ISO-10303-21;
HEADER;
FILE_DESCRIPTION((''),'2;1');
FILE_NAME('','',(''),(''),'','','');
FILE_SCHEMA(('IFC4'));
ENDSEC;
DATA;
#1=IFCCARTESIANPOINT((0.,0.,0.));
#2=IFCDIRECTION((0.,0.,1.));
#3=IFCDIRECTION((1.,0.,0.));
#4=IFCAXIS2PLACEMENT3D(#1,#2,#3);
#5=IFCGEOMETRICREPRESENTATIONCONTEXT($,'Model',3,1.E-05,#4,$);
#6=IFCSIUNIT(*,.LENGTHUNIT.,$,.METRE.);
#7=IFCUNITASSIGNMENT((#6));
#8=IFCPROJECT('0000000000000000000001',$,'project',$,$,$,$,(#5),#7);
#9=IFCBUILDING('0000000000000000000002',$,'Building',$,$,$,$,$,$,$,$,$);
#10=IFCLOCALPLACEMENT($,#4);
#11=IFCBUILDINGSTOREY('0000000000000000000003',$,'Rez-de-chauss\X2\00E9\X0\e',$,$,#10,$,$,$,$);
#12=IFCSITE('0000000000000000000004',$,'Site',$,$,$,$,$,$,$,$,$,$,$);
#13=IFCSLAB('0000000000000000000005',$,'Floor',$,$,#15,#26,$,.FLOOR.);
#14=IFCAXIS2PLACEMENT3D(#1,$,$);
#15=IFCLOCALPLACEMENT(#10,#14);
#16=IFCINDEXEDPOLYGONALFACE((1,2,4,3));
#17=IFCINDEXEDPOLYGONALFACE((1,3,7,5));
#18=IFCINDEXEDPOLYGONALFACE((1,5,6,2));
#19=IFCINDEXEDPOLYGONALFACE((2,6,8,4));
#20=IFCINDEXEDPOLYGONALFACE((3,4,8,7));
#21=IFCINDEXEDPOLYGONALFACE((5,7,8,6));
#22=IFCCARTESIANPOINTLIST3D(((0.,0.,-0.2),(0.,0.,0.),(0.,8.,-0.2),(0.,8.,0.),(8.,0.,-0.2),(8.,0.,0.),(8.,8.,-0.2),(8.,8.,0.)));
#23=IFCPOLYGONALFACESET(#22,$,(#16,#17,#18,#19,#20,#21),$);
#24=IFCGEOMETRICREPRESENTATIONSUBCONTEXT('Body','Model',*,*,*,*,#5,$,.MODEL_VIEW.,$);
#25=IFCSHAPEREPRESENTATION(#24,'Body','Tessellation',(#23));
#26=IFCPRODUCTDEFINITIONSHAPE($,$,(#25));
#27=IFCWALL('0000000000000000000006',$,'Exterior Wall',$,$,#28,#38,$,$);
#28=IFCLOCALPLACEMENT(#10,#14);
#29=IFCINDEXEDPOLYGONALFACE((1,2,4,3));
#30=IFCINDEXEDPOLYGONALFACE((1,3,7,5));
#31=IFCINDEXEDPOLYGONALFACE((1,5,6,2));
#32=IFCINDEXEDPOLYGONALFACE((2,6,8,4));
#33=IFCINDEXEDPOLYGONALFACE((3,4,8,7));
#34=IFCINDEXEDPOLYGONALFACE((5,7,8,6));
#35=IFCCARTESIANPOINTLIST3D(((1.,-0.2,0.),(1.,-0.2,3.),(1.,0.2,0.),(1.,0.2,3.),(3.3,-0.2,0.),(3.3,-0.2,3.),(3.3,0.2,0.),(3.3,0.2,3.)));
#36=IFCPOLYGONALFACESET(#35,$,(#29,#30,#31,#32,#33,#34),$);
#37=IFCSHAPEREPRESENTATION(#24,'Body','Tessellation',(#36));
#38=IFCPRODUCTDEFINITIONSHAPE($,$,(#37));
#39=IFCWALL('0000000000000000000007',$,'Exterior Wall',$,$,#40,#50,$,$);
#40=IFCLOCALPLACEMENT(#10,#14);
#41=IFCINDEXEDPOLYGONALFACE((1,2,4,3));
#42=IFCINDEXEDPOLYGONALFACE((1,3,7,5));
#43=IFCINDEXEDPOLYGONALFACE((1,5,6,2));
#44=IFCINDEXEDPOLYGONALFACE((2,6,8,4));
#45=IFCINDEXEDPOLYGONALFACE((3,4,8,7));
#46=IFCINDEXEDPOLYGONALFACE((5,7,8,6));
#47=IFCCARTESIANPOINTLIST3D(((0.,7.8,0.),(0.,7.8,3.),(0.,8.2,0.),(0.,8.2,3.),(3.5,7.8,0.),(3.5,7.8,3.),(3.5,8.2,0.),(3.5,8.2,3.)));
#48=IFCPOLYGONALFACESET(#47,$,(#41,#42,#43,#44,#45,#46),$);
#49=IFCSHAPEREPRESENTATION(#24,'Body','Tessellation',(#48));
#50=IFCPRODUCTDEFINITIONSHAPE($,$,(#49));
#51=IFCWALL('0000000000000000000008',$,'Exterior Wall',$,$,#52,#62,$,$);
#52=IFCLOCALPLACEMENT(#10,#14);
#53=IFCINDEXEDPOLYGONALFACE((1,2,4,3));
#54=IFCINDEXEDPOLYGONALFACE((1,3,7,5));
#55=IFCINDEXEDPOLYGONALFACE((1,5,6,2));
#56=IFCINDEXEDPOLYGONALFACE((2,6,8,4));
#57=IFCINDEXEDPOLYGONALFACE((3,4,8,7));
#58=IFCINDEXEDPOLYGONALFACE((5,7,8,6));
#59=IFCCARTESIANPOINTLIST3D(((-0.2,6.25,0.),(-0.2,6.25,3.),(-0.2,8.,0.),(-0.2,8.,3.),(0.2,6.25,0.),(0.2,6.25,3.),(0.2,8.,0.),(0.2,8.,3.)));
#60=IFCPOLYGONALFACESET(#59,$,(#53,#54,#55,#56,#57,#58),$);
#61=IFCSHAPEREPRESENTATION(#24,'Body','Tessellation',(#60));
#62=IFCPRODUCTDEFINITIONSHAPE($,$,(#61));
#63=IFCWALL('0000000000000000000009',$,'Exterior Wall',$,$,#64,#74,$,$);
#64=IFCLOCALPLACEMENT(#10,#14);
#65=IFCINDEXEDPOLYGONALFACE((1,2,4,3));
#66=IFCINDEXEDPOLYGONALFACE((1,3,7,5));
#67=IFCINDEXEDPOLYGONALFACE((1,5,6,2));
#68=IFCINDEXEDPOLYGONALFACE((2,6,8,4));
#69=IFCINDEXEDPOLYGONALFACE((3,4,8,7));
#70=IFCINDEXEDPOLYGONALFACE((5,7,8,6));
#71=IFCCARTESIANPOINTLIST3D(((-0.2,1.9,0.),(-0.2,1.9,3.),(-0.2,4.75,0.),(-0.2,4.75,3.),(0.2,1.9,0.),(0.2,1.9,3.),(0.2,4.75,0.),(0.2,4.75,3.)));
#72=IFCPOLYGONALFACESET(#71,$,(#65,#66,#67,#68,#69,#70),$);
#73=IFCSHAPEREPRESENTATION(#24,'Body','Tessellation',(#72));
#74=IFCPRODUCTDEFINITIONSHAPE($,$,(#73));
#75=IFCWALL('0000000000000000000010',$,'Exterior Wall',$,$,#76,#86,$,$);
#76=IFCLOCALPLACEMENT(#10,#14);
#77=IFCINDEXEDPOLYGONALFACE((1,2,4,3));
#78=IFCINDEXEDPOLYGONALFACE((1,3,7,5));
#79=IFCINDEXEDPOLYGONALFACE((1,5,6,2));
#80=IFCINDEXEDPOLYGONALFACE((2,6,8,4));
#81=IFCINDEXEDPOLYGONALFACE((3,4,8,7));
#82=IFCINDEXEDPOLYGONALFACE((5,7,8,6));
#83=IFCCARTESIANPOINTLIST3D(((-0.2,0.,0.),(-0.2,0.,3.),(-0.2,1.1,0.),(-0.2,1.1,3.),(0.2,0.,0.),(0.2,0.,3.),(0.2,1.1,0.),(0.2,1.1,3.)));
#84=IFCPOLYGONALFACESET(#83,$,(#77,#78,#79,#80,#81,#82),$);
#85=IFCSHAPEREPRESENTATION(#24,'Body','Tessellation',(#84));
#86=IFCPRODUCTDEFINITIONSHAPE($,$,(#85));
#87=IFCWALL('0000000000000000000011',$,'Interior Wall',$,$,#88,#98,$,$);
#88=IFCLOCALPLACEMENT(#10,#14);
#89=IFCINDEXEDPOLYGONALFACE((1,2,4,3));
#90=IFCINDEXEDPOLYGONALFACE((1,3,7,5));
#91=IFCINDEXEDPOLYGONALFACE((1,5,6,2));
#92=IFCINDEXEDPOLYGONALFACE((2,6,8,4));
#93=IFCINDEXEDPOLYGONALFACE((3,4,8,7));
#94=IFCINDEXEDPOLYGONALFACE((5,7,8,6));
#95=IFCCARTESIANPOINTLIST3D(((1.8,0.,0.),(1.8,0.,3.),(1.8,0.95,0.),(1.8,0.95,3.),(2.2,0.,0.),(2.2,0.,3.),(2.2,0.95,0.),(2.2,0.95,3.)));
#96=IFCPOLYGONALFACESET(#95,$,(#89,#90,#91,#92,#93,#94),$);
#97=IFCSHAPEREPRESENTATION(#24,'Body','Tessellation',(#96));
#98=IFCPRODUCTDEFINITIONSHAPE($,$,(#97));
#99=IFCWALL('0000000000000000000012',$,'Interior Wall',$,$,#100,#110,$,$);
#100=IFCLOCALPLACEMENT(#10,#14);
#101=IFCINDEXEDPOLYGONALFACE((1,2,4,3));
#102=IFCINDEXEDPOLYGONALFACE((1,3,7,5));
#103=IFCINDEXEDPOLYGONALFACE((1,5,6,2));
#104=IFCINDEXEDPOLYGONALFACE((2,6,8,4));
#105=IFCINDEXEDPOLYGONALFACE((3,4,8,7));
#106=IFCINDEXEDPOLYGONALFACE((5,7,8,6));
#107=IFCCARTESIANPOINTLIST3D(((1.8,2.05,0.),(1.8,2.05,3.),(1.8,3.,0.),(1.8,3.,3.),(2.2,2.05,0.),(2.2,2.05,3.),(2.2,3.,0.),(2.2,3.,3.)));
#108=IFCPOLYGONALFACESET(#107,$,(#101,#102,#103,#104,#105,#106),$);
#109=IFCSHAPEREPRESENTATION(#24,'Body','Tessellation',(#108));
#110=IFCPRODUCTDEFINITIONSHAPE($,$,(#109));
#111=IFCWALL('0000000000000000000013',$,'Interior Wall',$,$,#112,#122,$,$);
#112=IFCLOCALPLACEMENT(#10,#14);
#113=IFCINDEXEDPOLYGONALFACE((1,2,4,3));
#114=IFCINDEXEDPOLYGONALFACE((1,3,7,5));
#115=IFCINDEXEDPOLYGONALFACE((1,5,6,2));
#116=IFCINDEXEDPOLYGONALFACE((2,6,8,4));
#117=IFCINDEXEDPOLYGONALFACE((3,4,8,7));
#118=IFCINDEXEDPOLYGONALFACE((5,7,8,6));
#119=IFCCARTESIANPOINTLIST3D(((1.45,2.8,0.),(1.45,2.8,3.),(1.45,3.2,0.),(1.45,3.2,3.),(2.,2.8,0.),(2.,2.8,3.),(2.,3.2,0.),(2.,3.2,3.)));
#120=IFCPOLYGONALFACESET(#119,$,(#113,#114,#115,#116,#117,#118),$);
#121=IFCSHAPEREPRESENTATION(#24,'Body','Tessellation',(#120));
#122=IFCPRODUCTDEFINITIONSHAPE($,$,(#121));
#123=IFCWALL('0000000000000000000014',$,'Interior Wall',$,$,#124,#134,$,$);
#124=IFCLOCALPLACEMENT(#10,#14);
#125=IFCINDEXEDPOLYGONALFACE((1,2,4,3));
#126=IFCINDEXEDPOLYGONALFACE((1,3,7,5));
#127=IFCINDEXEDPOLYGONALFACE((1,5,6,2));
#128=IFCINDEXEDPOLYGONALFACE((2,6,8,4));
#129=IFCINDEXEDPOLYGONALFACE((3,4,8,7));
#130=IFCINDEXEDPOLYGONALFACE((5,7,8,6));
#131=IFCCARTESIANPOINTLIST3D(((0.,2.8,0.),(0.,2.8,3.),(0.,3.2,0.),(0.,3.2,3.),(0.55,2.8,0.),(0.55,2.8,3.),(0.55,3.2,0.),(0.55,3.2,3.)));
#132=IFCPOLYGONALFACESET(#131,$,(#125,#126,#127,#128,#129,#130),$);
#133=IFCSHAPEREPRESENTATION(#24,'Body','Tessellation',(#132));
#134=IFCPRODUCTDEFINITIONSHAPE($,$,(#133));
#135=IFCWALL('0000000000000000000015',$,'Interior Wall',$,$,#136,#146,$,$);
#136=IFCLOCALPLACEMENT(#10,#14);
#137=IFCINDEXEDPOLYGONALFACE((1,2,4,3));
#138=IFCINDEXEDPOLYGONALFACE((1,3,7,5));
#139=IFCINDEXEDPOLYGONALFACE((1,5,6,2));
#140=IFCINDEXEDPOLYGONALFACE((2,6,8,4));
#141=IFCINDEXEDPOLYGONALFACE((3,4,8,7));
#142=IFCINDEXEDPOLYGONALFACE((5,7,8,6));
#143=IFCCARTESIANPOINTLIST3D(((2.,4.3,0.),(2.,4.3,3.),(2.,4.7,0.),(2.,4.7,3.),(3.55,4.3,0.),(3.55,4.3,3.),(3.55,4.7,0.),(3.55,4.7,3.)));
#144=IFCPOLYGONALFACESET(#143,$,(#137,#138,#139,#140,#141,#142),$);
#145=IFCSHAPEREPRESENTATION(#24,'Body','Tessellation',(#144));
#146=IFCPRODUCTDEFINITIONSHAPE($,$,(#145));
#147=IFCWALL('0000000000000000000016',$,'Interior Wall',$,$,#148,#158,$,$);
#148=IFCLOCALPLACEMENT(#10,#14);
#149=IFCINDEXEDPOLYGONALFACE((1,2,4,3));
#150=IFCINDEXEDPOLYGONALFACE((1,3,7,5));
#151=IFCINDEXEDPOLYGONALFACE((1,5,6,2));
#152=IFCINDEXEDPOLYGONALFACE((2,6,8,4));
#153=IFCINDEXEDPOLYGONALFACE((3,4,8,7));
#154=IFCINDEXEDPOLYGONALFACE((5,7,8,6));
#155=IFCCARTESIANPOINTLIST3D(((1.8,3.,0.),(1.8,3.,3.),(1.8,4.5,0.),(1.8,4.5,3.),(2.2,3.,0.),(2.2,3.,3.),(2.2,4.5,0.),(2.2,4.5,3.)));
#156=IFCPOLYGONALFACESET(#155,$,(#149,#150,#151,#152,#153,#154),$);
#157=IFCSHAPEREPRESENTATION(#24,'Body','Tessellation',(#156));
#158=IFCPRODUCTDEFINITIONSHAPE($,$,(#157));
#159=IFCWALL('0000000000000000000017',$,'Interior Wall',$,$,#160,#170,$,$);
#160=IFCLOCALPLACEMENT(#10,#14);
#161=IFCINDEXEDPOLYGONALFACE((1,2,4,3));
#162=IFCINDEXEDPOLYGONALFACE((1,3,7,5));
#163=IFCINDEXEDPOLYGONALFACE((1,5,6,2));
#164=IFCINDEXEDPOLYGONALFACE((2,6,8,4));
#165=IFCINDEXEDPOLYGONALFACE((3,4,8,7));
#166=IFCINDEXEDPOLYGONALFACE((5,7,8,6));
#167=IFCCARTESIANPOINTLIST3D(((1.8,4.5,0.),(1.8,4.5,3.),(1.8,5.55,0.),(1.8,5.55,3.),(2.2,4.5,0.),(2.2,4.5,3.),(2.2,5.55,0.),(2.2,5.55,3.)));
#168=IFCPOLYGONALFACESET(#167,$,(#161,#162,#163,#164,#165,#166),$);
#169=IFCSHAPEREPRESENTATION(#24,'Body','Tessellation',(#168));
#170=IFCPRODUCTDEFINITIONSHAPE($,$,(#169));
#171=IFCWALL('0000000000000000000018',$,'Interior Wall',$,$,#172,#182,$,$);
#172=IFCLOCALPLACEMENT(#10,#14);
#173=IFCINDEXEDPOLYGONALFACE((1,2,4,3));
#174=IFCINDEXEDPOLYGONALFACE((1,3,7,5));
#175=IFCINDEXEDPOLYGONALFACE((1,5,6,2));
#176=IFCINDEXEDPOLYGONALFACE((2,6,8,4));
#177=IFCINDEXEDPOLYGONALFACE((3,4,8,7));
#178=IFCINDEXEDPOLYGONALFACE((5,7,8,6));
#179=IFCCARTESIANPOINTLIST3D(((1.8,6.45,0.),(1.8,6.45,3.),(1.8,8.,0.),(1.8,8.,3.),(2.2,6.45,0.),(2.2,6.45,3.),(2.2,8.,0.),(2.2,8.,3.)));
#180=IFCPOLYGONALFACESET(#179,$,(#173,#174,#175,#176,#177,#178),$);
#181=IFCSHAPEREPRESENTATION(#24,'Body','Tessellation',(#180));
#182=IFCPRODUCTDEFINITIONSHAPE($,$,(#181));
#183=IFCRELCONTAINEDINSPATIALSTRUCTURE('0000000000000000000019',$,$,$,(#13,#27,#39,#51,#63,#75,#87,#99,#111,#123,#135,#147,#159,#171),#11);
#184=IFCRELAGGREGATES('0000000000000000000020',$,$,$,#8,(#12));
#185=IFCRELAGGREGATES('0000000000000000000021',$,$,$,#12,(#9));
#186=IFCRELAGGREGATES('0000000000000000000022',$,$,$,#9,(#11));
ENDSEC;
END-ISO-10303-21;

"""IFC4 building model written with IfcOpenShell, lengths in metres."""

from ifc_helpers import new_model, si_unit, frame, origin_with_axes, place, context, subcontext, project, spatial, indexed_curve, outline, extrude, element, save


model = new_model("IFC4")

# Units and contexts
model_context = context("Model", 3, precision=1e-05, world=origin_with_axes())
body_context = subcontext(model_context, "Body", "Model", "MODEL_VIEW")
ifc_project = project(units=[si_unit("LENGTHUNIT", "METRE")], contexts=[model_context])

# Site, building, storey
site = spatial("IfcSite", under=ifc_project, Name="Site")
building = spatial("IfcBuilding", under=site, Name="Building")
storey_placement = place(None, origin_with_axes())
storey = spatial("IfcBuildingStorey", under=building, at=storey_placement, Name="Rez-de-chaussée")

# Slab
slab_placement = place(storey_placement, frame((0.0, 0.0, -0.2), z_axis=(0.0, 0.0, 1.0), x_axis=(1.0, 0.0, 0.0)))
element("IfcSlab", 1, at=slab_placement, inside=storey, Name="Floor", PredefinedType="FLOOR", context=body_context, shape_type="SweptSolid", body=[
    extrude(outline(indexed_curve([(0.0, 0.0), (8.0, 0.0), (8.0, 8.0), (0.0, 8.0)])), None, (0.0, 0.0, 1.0), 0.2),
])

# Walls
wall_1_placement = place(storey_placement, frame((1.0, 0.0, 0.0), z_axis=(0.0, 0.0, 1.0), x_axis=(1.0, 0.0, 0.0)))
element("IfcWall", 2, at=wall_1_placement, inside=storey, Name="Exterior Wall", context=body_context, shape_type="SweptSolid", body=[
    extrude(outline(indexed_curve([(0.0, 0.0), (0.0, 0.4), (2.3, 0.4), (2.3, 0.0), (0.0, 0.0)], self_intersect=False)), frame((0.0, -0.2, 0.0), z_axis=(0.0, 0.0, 1.0), x_axis=(1.0, 0.0, 0.0)), (0.0, 0.0, 1.0), 3.0),
])
wall_2_placement = place(storey_placement, frame((3.5, 8.0, 0.0), z_axis=(0.0, 0.0, 1.0), x_axis=(-1.0, 0.0, 0.0)))
element("IfcWall", 3, at=wall_2_placement, inside=storey, Name="Exterior Wall", context=body_context, shape_type="SweptSolid", body=[
    extrude(outline(indexed_curve([(0.0, 0.0), (0.0, 0.4), (3.5, 0.4), (3.5, 0.0), (0.0, 0.0)], self_intersect=False)), frame((0.0, -0.2, 0.0), z_axis=(0.0, 0.0, 1.0), x_axis=(1.0, 0.0, 0.0)), (0.0, 0.0, 1.0), 3.0),
])
wall_3_placement = place(storey_placement, frame((0.0, 8.0, 0.0), z_axis=(0.0, 0.0, 1.0), x_axis=(0.0, -1.0, 0.0)))
element("IfcWall", 4, at=wall_3_placement, inside=storey, Name="Exterior Wall", context=body_context, shape_type="SweptSolid", body=[
    extrude(outline(indexed_curve([(0.0, 0.0), (0.0, 0.4), (1.75, 0.4), (1.75, 0.0), (0.0, 0.0)], self_intersect=False)), frame((0.0, -0.2, 0.0), z_axis=(0.0, 0.0, 1.0), x_axis=(1.0, 0.0, 0.0)), (0.0, 0.0, 1.0), 3.0),
])
wall_4_placement = place(storey_placement, frame((0.0, 4.75, 0.0), z_axis=(0.0, 0.0, 1.0), x_axis=(0.0, -1.0, 0.0)))
element("IfcWall", 5, at=wall_4_placement, inside=storey, Name="Exterior Wall", context=body_context, shape_type="SweptSolid", body=[
    extrude(outline(indexed_curve([(0.0, 0.0), (0.0, 0.4), (2.85, 0.4), (2.85, 0.0), (0.0, 0.0)], self_intersect=False)), frame((0.0, -0.2, 0.0), z_axis=(0.0, 0.0, 1.0), x_axis=(1.0, 0.0, 0.0)), (0.0, 0.0, 1.0), 3.0),
])
wall_5_placement = place(storey_placement, frame((0.0, 1.1, 0.0), z_axis=(0.0, 0.0, 1.0), x_axis=(0.0, -1.0, 0.0)))
element("IfcWall", 6, at=wall_5_placement, inside=storey, Name="Exterior Wall", context=body_context, shape_type="SweptSolid", body=[
    extrude(outline(indexed_curve([(0.0, 0.0), (0.0, 0.4), (1.1, 0.4), (1.1, 0.0), (0.0, 0.0)], self_intersect=False)), frame((0.0, -0.2, 0.0), z_axis=(0.0, 0.0, 1.0), x_axis=(1.0, 0.0, 0.0)), (0.0, 0.0, 1.0), 3.0),
])
wall_6_placement = place(storey_placement, frame((2.0, 0.0, 0.0), z_axis=(0.0, 0.0, 1.0), x_axis=(0.0, 1.0, 0.0)))
element("IfcWall", 7, at=wall_6_placement, inside=storey, Name="Interior Wall", context=body_context, shape_type="SweptSolid", body=[
    extrude(outline(indexed_curve([(0.0, 0.0), (0.0, 0.4), (0.95, 0.4), (0.95, 0.0), (0.0, 0.0)], self_intersect=False)), frame((0.0, -0.2, 0.0), z_axis=(0.0, 0.0, 1.0), x_axis=(1.0, 0.0, 0.0)), (0.0, 0.0, 1.0), 3.0),
])
wall_7_placement = place(storey_placement, frame((2.0, 2.05, 0.0), z_axis=(0.0, 0.0, 1.0), x_axis=(0.0, 1.0, 0.0)))
element("IfcWall", 8, at=wall_7_placement, inside=storey, Name="Interior Wall", context=body_context, shape_type="SweptSolid", body=[
    extrude(outline(indexed_curve([(0.0, 0.0), (0.0, 0.4), (0.95, 0.4), (0.95, 0.0), (0.0, 0.0)], self_intersect=False)), frame((0.0, -0.2, 0.0), z_axis=(0.0, 0.0, 1.0), x_axis=(1.0, 0.0, 0.0)), (0.0, 0.0, 1.0), 3.0),
])
for number, where, z_axis, x_axis, name in (
    (9, (2.0, 3.0, 0.0), (0.0, 0.0, 1.0), (-1.0, 0.0, 0.0), "Interior Wall"),
    (10, (0.55, 3.0, 0.0), (0.0, 0.0, 1.0), (-1.0, 0.0, 0.0), "Interior Wall"),
):
    element("IfcWall", number, at=place(storey_placement, frame(where, z_axis=z_axis, x_axis=x_axis)), inside=storey, Name=name, context=body_context, shape_type="SweptSolid", body=[
        extrude(outline(indexed_curve([(0.0, 0.0), (0.0, 0.4), (0.55, 0.4), (0.55, 0.0), (0.0, 0.0)], self_intersect=False)), frame((0.0, -0.2, 0.0), z_axis=(0.0, 0.0, 1.0), x_axis=(1.0, 0.0, 0.0)), (0.0, 0.0, 1.0), 3.0),
    ])
wall_8_placement = place(storey_placement, frame((3.55, 4.5, 0.0), z_axis=(0.0, 0.0, 1.0), x_axis=(-1.0, 0.0, 0.0)))
element("IfcWall", 11, at=wall_8_placement, inside=storey, Name="Interior Wall", context=body_context, shape_type="SweptSolid", body=[
    extrude(outline(indexed_curve([(0.0, 0.0), (0.0, 0.4), (1.55, 0.4), (1.55, 0.0), (0.0, 0.0)], self_intersect=False)), frame((0.0, -0.2, 0.0), z_axis=(0.0, 0.0, 1.0), x_axis=(1.0, 0.0, 0.0)), (0.0, 0.0, 1.0), 3.0),
])
wall_9_placement = place(storey_placement, frame((2.0, 4.5, 0.0), z_axis=(0.0, 0.0, 1.0), x_axis=(0.0, -1.0, 0.0)))
element("IfcWall", 12, at=wall_9_placement, inside=storey, Name="Interior Wall", context=body_context, shape_type="SweptSolid", body=[
    extrude(outline(indexed_curve([(0.0, 0.0), (0.0, 0.4), (1.5, 0.4), (1.5, 0.0), (0.0, 0.0)], self_intersect=False)), frame((0.0, -0.2, 0.0), z_axis=(0.0, 0.0, 1.0), x_axis=(1.0, 0.0, 0.0)), (0.0, 0.0, 1.0), 3.0),
])
wall_10_placement = place(storey_placement, frame((2.0, 4.5, 0.0), z_axis=(0.0, 0.0, 1.0), x_axis=(0.0, 1.0, 0.0)))
element("IfcWall", 13, at=wall_10_placement, inside=storey, Name="Interior Wall", context=body_context, shape_type="SweptSolid", body=[
    extrude(outline(indexed_curve([(0.0, 0.0), (0.0, 0.4), (1.05, 0.4), (1.05, 0.0), (0.0, 0.0)], self_intersect=False)), frame((0.0, -0.2, 0.0), z_axis=(0.0, 0.0, 1.0), x_axis=(1.0, 0.0, 0.0)), (0.0, 0.0, 1.0), 3.0),
])
wall_11_placement = place(storey_placement, frame((2.0, 6.45, 0.0), z_axis=(0.0, 0.0, 1.0), x_axis=(0.0, 1.0, 0.0)))
element("IfcWall", 14, at=wall_11_placement, inside=storey, Name="Interior Wall", context=body_context, shape_type="SweptSolid", body=[
    extrude(outline(indexed_curve([(0.0, 0.0), (0.0, 0.4), (1.55, 0.4), (1.55, 0.0), (0.0, 0.0)], self_intersect=False)), frame((0.0, -0.2, 0.0), z_axis=(0.0, 0.0, 1.0), x_axis=(1.0, 0.0, 0.0)), (0.0, 0.0, 1.0), 3.0),
])

save(model, "model.ifc")
